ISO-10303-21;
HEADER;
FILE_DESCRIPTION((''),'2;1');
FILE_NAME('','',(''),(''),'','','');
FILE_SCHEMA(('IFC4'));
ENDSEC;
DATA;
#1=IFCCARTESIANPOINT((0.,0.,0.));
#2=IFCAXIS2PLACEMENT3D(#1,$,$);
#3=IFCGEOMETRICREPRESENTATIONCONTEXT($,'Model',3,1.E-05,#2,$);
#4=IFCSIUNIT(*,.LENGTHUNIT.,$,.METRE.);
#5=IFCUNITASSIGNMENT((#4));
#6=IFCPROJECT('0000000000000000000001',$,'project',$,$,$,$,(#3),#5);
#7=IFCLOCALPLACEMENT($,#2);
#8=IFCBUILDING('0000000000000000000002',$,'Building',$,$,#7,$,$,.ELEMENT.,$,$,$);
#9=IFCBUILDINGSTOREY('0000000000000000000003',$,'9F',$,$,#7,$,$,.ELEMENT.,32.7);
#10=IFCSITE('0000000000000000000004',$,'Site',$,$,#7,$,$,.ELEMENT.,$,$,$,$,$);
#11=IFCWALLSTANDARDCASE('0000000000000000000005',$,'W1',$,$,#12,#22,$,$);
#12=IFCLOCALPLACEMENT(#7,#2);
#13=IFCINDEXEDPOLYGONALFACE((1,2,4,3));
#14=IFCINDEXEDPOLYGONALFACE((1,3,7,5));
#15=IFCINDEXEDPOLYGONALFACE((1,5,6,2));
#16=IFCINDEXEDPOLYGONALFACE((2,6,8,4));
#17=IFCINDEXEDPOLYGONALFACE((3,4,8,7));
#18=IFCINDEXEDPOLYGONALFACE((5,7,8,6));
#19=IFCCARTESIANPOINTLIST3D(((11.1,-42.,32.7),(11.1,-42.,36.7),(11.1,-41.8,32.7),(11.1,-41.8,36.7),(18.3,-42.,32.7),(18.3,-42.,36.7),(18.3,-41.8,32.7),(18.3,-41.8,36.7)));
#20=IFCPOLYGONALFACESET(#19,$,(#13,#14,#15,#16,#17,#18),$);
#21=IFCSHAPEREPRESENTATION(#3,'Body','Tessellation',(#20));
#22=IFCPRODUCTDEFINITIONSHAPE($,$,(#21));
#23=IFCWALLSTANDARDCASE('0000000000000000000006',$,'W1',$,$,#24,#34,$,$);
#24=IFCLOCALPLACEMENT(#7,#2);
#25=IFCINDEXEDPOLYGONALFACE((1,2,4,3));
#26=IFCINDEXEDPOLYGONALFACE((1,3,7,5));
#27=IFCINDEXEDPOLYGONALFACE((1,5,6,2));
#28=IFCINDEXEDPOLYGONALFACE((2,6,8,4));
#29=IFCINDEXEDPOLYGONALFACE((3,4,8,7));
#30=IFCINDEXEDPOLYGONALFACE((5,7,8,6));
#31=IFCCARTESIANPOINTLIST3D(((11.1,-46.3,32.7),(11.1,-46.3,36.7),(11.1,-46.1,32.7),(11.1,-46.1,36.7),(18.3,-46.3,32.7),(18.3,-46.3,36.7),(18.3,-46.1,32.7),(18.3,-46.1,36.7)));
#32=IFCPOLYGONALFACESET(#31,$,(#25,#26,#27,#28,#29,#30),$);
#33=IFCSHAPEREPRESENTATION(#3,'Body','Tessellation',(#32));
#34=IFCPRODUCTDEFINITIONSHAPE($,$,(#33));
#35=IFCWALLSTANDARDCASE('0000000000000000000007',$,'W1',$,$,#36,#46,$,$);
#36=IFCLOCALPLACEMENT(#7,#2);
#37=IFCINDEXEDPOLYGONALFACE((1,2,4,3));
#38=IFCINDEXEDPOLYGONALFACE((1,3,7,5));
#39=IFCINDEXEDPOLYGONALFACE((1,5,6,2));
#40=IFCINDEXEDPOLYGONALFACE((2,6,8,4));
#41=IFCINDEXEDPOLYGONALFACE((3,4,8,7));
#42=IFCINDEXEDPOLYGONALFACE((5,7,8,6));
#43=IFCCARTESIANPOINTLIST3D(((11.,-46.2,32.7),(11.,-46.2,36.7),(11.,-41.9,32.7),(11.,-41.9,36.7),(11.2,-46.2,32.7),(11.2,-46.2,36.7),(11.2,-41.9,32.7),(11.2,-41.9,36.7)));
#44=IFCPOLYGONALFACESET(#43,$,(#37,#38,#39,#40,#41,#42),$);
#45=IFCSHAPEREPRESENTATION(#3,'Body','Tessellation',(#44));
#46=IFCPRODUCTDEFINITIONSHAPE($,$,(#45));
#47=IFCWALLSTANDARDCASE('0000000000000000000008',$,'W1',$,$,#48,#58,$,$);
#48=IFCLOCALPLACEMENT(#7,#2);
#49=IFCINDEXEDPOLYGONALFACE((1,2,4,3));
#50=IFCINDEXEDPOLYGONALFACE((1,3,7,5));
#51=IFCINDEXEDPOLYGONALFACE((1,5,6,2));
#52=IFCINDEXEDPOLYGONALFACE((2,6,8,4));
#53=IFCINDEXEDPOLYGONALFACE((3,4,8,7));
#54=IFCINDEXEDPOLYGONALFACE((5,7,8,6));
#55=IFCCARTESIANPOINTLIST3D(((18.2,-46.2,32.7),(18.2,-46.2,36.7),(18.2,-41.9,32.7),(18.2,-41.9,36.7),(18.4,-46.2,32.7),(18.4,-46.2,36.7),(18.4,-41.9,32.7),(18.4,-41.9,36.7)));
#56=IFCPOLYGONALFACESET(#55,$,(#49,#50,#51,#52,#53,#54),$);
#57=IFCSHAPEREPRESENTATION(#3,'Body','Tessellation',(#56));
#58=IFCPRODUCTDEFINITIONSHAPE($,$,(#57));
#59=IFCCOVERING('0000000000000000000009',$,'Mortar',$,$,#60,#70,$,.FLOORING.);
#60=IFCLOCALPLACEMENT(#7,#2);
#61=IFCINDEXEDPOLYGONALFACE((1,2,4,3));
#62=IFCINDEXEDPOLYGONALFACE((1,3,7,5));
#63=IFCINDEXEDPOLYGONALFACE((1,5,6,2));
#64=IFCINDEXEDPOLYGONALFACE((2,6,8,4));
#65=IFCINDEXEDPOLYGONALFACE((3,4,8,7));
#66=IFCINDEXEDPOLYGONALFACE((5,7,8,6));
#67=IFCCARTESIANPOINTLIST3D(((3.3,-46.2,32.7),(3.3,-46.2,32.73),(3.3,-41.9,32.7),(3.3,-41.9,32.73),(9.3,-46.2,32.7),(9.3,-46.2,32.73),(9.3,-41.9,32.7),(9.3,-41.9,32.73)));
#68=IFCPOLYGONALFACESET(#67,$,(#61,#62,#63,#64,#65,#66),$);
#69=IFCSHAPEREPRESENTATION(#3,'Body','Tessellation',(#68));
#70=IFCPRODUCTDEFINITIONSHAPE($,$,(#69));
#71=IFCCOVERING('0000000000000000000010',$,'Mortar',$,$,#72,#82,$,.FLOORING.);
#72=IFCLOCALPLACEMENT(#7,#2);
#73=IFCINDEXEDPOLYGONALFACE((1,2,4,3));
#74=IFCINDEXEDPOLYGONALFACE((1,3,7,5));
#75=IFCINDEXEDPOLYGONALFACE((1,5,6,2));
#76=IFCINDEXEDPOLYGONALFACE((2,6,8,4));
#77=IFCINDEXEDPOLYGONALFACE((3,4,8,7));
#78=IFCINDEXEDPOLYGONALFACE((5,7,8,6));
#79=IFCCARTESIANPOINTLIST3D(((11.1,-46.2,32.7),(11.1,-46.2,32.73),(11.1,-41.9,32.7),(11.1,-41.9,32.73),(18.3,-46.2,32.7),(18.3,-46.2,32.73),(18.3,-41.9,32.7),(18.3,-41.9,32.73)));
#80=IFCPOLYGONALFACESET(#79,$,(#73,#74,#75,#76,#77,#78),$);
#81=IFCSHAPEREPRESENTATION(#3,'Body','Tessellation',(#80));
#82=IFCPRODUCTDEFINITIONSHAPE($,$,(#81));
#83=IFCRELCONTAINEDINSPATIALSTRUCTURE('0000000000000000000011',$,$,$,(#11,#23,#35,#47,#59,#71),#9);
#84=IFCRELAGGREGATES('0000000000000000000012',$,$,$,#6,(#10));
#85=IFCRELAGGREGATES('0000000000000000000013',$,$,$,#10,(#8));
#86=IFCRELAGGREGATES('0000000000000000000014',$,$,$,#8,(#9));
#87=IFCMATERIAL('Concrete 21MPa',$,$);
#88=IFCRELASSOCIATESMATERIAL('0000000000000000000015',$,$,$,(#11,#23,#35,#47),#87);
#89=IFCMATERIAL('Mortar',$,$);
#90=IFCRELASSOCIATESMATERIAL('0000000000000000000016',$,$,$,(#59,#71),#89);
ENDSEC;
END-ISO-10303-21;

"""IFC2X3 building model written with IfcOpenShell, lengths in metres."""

from ifc_helpers import new_model, si_unit, frame, origin, origin_2d, place, context, project, spatial, rectangle, extrude, material, element, save


model = new_model("IFC2X3")

# Units and contexts
model_context = context("Model", 3, precision=1e-05, world=origin())
ifc_project = project(units=[si_unit("LENGTHUNIT", "METRE")], contexts=[model_context])

# Site, building, storey
placement = place(None, origin())
site = spatial("IfcSite", under=ifc_project, at=placement, Name="Site", CompositionType="ELEMENT")
building = spatial("IfcBuilding", under=site, at=placement, Name="Building", CompositionType="ELEMENT")
storey = spatial("IfcBuildingStorey", under=building, at=placement, Name="9F", CompositionType="ELEMENT", Elevation=32.7)

# Shared definitions
ifc_material_1 = material(Name="Concrete 21MPa")

# Walls
for number, where, name in (
    (1, (14.7, -41.9, 32.7), "W1"),
    (2, (14.7, -46.2, 32.7), "W1"),
):
    element("IfcWallStandardCase", number, at=place(None, frame(where)), inside=storey, material=ifc_material_1, Name=name, context=model_context, shape_type="SweptSolid", body=[
        extrude(rectangle(XDim=7.2, YDim=0.2, at=origin_2d()), origin(), (0.0, 0.0, 1.0), 4.0),
    ])
for number, where, name in (
    (3, (11.1, -44.05, 32.7), "W1"),
    (4, (18.3, -44.05, 32.7), "W1"),
):
    element("IfcWallStandardCase", number, at=place(None, frame(where)), inside=storey, material=ifc_material_1, Name=name, context=model_context, shape_type="SweptSolid", body=[
        extrude(rectangle(XDim=0.2, YDim=4.3, at=origin_2d()), origin(), (0.0, 0.0, 1.0), 4.0),
    ])

# Coverings
ifc_material_2 = material(Name="Mortar")
covering_1_placement = place(None, frame((6.3, -44.05, 32.7)))
element("IfcCovering", 5, at=covering_1_placement, inside=storey, material=ifc_material_2, Name="Mortar", PredefinedType="FLOORING", context=model_context, shape_type="SweptSolid", body=[
    extrude(rectangle(XDim=6.0, YDim=4.3, at=origin_2d()), origin(), (0.0, 0.0, 1.0), 0.03),
])
covering_2_placement = place(None, frame((14.7, -44.05, 32.7)))
element("IfcCovering", 6, at=covering_2_placement, inside=storey, material=ifc_material_2, Name="Mortar", PredefinedType="FLOORING", context=model_context, shape_type="SweptSolid", body=[
    extrude(rectangle(XDim=7.2, YDim=4.3, at=origin_2d()), origin(), (0.0, 0.0, 1.0), 0.03),
])

save(model, "model.ifc")
